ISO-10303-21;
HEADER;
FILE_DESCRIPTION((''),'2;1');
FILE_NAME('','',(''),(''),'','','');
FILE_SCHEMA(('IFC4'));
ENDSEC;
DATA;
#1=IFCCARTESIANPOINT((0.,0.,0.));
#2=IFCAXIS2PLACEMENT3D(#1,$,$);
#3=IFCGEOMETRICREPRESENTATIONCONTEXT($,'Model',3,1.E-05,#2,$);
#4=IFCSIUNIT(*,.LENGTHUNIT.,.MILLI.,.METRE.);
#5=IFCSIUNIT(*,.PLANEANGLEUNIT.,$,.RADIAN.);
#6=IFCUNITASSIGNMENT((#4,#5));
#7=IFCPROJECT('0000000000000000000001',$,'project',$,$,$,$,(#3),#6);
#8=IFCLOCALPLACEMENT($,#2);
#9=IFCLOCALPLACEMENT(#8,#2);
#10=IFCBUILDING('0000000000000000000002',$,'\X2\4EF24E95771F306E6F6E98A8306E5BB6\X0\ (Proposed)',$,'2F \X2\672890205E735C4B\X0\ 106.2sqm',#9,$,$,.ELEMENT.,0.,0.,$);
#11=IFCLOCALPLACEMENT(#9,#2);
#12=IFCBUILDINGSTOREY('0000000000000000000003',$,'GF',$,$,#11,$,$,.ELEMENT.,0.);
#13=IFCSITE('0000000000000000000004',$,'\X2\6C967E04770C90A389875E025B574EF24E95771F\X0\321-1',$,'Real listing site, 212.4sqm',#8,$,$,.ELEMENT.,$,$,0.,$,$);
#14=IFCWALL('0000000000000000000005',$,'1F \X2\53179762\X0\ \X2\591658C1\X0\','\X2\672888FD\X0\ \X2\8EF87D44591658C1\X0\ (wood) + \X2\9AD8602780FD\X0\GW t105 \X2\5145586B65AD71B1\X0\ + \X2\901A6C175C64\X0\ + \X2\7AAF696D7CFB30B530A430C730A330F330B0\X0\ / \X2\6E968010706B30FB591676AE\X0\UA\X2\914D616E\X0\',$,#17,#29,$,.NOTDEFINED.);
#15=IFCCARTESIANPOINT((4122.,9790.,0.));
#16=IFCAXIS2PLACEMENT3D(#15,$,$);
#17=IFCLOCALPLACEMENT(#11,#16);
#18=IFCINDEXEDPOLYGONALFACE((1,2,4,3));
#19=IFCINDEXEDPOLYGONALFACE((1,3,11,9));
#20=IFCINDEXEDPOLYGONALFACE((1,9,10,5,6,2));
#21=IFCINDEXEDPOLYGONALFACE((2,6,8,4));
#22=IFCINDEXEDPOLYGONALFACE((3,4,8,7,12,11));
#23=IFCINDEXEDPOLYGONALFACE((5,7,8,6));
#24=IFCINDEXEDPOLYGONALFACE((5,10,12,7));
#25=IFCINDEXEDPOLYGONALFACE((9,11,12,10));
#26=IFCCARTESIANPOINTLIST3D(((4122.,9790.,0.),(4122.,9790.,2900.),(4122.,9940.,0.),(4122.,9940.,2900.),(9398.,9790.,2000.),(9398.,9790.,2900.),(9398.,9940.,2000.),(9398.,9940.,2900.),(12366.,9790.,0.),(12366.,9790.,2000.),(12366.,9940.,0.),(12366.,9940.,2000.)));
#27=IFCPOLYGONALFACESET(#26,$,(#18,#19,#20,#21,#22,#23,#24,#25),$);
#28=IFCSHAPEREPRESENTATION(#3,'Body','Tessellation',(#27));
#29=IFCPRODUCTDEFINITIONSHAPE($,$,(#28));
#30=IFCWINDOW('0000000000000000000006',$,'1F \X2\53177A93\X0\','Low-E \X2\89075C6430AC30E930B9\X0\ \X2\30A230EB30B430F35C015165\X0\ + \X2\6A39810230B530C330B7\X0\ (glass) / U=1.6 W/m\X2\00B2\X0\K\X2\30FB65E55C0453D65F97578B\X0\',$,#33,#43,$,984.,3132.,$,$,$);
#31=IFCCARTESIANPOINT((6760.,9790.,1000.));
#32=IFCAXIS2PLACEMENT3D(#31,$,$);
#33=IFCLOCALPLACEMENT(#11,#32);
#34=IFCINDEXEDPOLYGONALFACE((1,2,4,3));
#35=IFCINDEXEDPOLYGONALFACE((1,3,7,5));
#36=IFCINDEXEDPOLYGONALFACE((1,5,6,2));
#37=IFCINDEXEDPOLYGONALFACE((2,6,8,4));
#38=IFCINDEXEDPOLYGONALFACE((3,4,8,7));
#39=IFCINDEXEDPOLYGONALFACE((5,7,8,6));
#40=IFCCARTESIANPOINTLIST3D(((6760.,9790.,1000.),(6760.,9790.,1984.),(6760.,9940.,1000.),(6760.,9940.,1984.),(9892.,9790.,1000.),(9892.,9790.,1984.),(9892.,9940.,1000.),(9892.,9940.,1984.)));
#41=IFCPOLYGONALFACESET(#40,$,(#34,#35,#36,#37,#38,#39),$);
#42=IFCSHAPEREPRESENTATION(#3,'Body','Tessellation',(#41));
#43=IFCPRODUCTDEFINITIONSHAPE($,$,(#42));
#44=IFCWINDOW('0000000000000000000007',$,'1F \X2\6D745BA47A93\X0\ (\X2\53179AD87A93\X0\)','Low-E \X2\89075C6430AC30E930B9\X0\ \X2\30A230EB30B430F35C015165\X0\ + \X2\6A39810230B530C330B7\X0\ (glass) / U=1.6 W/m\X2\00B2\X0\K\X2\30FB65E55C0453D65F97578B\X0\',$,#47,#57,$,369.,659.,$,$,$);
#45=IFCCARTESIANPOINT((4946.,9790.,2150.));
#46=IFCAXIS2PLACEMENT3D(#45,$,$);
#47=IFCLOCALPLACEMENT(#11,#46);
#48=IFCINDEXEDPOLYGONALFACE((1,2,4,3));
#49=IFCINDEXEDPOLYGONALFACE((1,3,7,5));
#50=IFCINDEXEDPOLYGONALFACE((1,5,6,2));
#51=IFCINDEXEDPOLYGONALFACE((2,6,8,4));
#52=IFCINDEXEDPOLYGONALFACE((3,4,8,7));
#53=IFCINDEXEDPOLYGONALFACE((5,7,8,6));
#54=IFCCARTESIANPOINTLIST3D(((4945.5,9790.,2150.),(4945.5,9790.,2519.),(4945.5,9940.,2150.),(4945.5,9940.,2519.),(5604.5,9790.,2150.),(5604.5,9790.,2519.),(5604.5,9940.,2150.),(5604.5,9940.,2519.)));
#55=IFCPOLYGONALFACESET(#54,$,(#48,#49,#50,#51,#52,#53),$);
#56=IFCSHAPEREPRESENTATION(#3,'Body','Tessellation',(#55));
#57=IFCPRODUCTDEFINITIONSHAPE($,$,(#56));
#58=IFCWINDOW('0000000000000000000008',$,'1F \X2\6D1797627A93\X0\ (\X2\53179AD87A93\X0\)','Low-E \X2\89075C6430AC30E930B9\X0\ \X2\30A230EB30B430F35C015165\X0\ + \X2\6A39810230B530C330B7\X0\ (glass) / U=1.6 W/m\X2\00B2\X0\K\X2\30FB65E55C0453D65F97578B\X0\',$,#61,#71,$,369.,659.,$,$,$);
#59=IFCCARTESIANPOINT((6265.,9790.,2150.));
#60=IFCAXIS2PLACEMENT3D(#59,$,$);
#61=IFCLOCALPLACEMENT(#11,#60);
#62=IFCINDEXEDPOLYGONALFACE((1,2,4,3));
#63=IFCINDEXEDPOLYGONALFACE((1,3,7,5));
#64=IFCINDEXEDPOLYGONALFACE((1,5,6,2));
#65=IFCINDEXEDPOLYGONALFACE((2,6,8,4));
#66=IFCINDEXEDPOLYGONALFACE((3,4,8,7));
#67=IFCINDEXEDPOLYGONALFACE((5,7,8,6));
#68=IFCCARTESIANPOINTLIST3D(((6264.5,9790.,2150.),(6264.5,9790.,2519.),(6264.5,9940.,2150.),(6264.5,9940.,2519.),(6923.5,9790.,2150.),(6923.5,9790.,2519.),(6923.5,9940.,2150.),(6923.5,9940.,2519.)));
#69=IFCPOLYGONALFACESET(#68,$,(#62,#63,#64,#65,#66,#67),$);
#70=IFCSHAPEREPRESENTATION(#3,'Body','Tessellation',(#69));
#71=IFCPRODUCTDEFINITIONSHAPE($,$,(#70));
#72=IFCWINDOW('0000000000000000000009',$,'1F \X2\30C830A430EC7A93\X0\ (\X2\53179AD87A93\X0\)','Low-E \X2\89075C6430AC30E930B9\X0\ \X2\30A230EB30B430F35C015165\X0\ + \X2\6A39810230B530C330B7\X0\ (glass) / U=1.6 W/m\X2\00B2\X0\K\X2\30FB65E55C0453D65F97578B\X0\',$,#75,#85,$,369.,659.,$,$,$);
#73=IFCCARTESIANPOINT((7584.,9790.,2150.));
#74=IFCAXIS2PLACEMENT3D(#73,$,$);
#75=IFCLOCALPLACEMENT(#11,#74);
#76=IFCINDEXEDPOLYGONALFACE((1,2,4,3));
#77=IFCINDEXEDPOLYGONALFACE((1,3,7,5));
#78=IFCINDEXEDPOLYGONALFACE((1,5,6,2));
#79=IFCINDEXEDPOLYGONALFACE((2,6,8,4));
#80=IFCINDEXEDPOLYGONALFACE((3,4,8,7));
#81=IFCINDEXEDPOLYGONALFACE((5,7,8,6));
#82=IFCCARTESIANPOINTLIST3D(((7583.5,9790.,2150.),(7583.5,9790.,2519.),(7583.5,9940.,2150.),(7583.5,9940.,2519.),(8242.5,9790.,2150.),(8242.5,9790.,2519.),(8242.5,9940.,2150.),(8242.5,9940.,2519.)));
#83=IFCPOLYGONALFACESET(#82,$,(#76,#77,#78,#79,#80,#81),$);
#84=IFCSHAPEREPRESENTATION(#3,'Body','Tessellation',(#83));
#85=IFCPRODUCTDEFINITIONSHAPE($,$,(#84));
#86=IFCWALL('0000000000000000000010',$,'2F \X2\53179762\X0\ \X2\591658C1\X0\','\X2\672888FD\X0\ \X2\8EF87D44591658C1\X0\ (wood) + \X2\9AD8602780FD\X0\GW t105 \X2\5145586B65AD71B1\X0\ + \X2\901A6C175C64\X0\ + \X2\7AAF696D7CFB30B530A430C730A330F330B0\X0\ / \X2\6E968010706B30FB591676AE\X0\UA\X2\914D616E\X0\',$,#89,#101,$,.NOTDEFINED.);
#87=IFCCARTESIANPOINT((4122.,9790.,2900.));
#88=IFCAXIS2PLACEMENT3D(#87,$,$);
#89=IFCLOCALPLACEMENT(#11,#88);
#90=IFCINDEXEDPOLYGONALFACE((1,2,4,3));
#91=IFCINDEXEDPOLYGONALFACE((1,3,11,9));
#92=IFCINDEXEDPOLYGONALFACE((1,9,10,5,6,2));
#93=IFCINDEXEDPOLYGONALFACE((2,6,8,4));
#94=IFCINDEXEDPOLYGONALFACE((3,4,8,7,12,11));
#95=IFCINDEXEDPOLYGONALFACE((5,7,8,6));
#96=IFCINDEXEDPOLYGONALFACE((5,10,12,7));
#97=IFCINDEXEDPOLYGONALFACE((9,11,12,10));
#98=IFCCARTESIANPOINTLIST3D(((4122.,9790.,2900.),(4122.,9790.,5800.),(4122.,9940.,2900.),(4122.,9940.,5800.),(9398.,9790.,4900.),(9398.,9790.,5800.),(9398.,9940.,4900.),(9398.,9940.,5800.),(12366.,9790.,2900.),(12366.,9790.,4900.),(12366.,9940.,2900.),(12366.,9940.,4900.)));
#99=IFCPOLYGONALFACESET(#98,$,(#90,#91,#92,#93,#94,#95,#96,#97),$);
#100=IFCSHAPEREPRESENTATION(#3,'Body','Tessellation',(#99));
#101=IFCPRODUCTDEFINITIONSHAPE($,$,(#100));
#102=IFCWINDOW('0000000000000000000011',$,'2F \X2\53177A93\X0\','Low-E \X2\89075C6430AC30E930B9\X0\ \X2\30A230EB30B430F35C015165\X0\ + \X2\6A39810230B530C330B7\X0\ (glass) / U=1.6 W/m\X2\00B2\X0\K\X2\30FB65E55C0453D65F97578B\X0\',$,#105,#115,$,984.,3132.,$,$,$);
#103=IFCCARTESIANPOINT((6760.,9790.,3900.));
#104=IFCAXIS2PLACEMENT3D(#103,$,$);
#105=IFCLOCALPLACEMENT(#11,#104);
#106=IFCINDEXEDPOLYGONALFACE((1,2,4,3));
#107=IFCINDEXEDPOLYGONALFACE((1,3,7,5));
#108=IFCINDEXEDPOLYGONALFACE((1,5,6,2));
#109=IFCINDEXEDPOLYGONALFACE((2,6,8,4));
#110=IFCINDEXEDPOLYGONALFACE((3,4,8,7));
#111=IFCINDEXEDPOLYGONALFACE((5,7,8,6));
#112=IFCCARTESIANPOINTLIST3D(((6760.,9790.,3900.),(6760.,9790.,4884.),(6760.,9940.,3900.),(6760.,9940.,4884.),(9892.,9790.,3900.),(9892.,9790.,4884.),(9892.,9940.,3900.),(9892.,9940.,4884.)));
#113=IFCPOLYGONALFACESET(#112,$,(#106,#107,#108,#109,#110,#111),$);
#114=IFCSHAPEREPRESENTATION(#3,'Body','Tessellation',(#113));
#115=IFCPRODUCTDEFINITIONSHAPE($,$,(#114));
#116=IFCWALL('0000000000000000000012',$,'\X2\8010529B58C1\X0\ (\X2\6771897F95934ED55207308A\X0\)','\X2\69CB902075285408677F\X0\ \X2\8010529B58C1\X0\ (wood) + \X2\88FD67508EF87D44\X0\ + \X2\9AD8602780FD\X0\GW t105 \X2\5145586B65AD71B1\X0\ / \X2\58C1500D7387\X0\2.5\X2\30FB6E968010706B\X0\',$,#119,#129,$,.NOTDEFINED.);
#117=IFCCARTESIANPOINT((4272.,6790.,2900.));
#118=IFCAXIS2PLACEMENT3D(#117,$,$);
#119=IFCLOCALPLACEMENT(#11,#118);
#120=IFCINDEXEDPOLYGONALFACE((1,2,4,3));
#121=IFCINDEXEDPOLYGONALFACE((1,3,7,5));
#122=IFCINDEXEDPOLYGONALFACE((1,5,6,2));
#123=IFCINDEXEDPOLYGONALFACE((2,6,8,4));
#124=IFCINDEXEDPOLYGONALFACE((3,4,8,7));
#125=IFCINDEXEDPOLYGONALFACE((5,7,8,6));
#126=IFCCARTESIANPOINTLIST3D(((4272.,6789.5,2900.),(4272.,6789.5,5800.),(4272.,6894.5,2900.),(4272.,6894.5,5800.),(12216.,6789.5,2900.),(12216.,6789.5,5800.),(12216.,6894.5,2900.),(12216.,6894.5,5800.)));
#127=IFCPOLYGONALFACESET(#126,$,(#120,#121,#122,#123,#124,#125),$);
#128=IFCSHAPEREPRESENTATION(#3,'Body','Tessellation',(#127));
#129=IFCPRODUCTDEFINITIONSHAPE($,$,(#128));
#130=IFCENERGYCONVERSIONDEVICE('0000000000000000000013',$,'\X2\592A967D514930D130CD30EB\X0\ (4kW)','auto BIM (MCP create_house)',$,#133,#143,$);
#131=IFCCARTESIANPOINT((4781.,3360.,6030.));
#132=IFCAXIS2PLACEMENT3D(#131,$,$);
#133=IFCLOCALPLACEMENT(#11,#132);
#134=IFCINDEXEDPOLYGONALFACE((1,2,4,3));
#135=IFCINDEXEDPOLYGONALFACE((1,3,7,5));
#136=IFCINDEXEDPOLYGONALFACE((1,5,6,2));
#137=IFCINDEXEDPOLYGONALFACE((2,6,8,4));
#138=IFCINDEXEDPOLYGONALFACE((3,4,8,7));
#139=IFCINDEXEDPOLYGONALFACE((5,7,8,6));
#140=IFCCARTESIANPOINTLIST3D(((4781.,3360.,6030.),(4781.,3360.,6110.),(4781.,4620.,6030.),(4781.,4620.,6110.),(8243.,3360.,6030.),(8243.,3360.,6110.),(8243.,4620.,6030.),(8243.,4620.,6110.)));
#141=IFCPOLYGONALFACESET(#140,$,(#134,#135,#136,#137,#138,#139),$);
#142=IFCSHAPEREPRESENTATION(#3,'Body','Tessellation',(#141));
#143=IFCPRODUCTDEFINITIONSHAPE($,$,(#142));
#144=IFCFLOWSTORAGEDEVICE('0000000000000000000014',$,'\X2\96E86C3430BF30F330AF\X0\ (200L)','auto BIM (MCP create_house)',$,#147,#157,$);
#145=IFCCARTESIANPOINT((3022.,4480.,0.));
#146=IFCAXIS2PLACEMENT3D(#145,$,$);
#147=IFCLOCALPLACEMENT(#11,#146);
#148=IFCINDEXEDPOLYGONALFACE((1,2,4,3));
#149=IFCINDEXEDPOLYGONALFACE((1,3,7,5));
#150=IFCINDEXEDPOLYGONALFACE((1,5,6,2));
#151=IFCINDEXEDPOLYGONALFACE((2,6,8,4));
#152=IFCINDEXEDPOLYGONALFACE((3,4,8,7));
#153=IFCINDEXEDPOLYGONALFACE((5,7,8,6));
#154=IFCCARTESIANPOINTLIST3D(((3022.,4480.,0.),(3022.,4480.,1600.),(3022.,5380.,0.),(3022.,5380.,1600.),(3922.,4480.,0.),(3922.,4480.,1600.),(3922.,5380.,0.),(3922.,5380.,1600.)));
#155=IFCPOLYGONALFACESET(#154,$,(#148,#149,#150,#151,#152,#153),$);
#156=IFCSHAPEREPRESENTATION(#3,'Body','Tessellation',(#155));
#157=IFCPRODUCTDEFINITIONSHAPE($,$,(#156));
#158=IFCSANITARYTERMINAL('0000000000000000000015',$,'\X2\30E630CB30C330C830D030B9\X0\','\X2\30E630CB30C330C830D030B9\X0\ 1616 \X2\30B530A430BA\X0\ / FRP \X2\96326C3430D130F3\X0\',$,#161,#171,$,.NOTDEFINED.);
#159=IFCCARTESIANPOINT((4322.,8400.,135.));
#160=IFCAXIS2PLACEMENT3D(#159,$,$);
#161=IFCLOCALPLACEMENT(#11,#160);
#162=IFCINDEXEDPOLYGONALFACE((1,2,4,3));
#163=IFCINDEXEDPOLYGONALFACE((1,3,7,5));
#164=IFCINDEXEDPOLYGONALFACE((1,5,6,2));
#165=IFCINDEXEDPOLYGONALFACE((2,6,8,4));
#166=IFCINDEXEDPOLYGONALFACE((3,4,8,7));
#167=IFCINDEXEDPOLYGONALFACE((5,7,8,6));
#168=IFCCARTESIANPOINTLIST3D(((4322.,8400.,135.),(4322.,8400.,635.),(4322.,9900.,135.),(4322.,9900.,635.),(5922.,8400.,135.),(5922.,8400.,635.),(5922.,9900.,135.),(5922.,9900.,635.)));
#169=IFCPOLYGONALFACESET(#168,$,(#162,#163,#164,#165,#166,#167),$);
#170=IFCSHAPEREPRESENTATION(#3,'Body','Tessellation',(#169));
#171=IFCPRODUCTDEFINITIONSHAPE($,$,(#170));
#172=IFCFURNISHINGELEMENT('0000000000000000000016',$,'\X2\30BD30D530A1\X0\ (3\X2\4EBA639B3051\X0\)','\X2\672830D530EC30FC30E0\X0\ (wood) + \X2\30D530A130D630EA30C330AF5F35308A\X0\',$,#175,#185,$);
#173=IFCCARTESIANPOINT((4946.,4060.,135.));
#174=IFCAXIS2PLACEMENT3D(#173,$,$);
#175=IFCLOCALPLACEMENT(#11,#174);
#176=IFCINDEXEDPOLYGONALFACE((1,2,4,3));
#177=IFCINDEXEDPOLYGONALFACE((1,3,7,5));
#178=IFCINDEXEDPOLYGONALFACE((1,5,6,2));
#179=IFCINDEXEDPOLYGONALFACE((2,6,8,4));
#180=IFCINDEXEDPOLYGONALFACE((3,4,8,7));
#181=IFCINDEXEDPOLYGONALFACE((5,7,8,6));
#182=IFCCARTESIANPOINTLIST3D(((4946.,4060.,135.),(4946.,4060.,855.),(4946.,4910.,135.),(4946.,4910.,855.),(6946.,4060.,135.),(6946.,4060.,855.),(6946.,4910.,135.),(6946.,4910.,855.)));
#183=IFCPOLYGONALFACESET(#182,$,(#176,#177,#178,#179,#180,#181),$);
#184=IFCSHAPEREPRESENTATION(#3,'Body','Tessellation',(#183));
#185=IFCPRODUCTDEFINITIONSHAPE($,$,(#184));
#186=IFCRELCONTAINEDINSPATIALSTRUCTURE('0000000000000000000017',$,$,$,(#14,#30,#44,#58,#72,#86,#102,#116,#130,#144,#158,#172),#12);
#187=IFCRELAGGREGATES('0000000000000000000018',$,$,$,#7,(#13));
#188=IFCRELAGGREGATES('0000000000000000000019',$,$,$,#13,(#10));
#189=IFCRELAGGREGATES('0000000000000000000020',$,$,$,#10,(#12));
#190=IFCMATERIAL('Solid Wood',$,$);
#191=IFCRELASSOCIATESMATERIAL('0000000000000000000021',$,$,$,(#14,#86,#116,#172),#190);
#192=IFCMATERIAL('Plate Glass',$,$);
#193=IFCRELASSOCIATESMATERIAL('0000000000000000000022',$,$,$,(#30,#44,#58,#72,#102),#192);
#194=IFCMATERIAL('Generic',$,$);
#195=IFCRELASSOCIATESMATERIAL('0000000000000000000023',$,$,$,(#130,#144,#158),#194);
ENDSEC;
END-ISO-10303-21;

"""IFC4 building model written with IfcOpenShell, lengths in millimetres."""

from ifc_helpers import new_model, si_unit, frame, frame_2d, origin, place, context, project, spatial, rectangle, extrude, material, element, fill, save


model = new_model("IFC4")

# Units and contexts
model_context = context("Model", 3, precision=1e-05, world=origin())
ifc_project = project(units=[si_unit("LENGTHUNIT", "METRE", prefix="MILLI"), si_unit("PLANEANGLEUNIT", "RADIAN")], contexts=[model_context])

# Site, building, storey
site_placement = place(None, origin())
site = spatial("IfcSite", under=ifc_project, at=site_placement, Name="沖縄県那覇市字仲井真321-1", ObjectType="Real listing site, 212.4sqm", CompositionType="ELEMENT", RefElevation=0.0)
building_placement = place(site_placement, origin())
building = spatial("IfcBuilding", under=site, at=building_placement, Name="仲井真の潮風の家 (Proposed)", ObjectType="2F 木造平屋 106.2sqm", CompositionType="ELEMENT", ElevationOfRefHeight=0.0, ElevationOfTerrain=0.0)
storey_placement = place(building_placement, origin())
storey = spatial("IfcBuildingStorey", under=building, at=storey_placement, Name="GF", CompositionType="ELEMENT", Elevation=0.0)

# Wall, openings, windows
ifc_material_1 = material(Name="Solid Wood")
wall_1_placement = place(storey_placement, frame((4122.0, 9790.0, 0.0)))
wall_1 = element("IfcWall", 1, at=wall_1_placement, inside=storey, material=ifc_material_1, Name="1F 北面 外壁", Description="木製 軸組外壁 (wood) + 高性能GW t105 充填断熱 + 通気層 + 窯業系サイディング / 準耐火・外皮UA配慮", PredefinedType="NOTDEFINED", context=model_context, shape_type="SweptSolid", body=[
    extrude(rectangle(XDim=8244.0, YDim=150.0, at=frame_2d((4122.0, 75.0))), frame((4122.0, 9790.0, 0.0)), (0.0, 0.0, 1.0), 2900.0),
])
opening_1_placement = place(storey_placement, frame((6760.0, 9790.0, 1000.0)))
opening_1 = element("IfcOpeningElement", 2, at=opening_1_placement, cuts=wall_1, PredefinedType="NOTDEFINED", context=model_context, shape_type="SweptSolid", body=[
    extrude(rectangle(XDim=3132.0, YDim=150.0, at=frame_2d((1566.0, 75.0))), frame((6760.0, 9790.0, 1000.0)), (0.0, 0.0, 1.0), 984.0),
])
opening_2_placement = place(storey_placement, frame((4946.0, 9790.0, 2150.0)))
opening_2 = element("IfcOpeningElement", 3, at=opening_2_placement, cuts=wall_1, PredefinedType="NOTDEFINED", context=model_context, shape_type="SweptSolid", body=[
    extrude(rectangle(XDim=659.0, YDim=150.0, at=frame_2d((329.0, 75.0))), frame((4946.0, 9790.0, 2150.0)), (0.0, 0.0, 1.0), 369.0),
])
opening_3_placement = place(storey_placement, frame((6265.0, 9790.0, 2150.0)))
opening_3 = element("IfcOpeningElement", 4, at=opening_3_placement, cuts=wall_1, PredefinedType="NOTDEFINED", context=model_context, shape_type="SweptSolid", body=[
    extrude(rectangle(XDim=659.0, YDim=150.0, at=frame_2d((329.0, 75.0))), frame((6265.0, 9790.0, 2150.0)), (0.0, 0.0, 1.0), 369.0),
])
opening_4_placement = place(storey_placement, frame((7584.0, 9790.0, 2150.0)))
opening_4 = element("IfcOpeningElement", 5, at=opening_4_placement, cuts=wall_1, PredefinedType="NOTDEFINED", context=model_context, shape_type="SweptSolid", body=[
    extrude(rectangle(XDim=659.0, YDim=150.0, at=frame_2d((329.0, 75.0))), frame((7584.0, 9790.0, 2150.0)), (0.0, 0.0, 1.0), 369.0),
])
ifc_material_2 = material(Name="Plate Glass")
window_1_placement = place(storey_placement, frame((6760.0, 9790.0, 1000.0)))
window_1 = element("IfcWindow", 6, at=window_1_placement, inside=storey, material=ifc_material_2, Name="1F 北窓", Description="Low-E 複層ガラス アルゴン封入 + 樹脂サッシ (glass) / U=1.6 W/m²K・日射取得型", OverallHeight=984.0, OverallWidth=3132.0, context=model_context, shape_type="SweptSolid", body=[
    extrude(rectangle(XDim=3132.0, YDim=150.0, at=frame_2d((1566.0, 75.0))), frame((6760.0, 9790.0, 1000.0)), (0.0, 0.0, 1.0), 984.0),
])
fill(opening_1, window_1)
window_2_placement = place(storey_placement, frame((4946.0, 9790.0, 2150.0)))
window_2 = element("IfcWindow", 7, at=window_2_placement, inside=storey, material=ifc_material_2, Name="1F 浴室窓 (北高窓)", Description="Low-E 複層ガラス アルゴン封入 + 樹脂サッシ (glass) / U=1.6 W/m²K・日射取得型", OverallHeight=369.0, OverallWidth=659.0, context=model_context, shape_type="SweptSolid", body=[
    extrude(rectangle(XDim=659.0, YDim=150.0, at=frame_2d((329.0, 75.0))), frame((4946.0, 9790.0, 2150.0)), (0.0, 0.0, 1.0), 369.0),
])
fill(opening_2, window_2)
window_3_placement = place(storey_placement, frame((6265.0, 9790.0, 2150.0)))
window_3 = element("IfcWindow", 8, at=window_3_placement, inside=storey, material=ifc_material_2, Name="1F 洗面窓 (北高窓)", Description="Low-E 複層ガラス アルゴン封入 + 樹脂サッシ (glass) / U=1.6 W/m²K・日射取得型", OverallHeight=369.0, OverallWidth=659.0, context=model_context, shape_type="SweptSolid", body=[
    extrude(rectangle(XDim=659.0, YDim=150.0, at=frame_2d((329.0, 75.0))), frame((6265.0, 9790.0, 2150.0)), (0.0, 0.0, 1.0), 369.0),
])
fill(opening_3, window_3)
window_4_placement = place(storey_placement, frame((7584.0, 9790.0, 2150.0)))
window_4 = element("IfcWindow", 9, at=window_4_placement, inside=storey, material=ifc_material_2, Name="1F トイレ窓 (北高窓)", Description="Low-E 複層ガラス アルゴン封入 + 樹脂サッシ (glass) / U=1.6 W/m²K・日射取得型", OverallHeight=369.0, OverallWidth=659.0, context=model_context, shape_type="SweptSolid", body=[
    extrude(rectangle(XDim=659.0, YDim=150.0, at=frame_2d((329.0, 75.0))), frame((7584.0, 9790.0, 2150.0)), (0.0, 0.0, 1.0), 369.0),
])
fill(opening_4, window_4)

# Wall, opening, window
wall_2_placement = place(storey_placement, frame((4122.0, 9790.0, 2900.0)))
wall_2 = element("IfcWall", 10, at=wall_2_placement, inside=storey, material=ifc_material_1, Name="2F 北面 外壁", Description="木製 軸組外壁 (wood) + 高性能GW t105 充填断熱 + 通気層 + 窯業系サイディング / 準耐火・外皮UA配慮", PredefinedType="NOTDEFINED", context=model_context, shape_type="SweptSolid", body=[
    extrude(rectangle(XDim=8244.0, YDim=150.0, at=frame_2d((4122.0, 75.0))), frame((4122.0, 9790.0, 2900.0)), (0.0, 0.0, 1.0), 2900.0),
])
opening_5_placement = place(storey_placement, frame((6760.0, 9790.0, 3900.0)))
opening_5 = element("IfcOpeningElement", 11, at=opening_5_placement, cuts=wall_2, PredefinedType="NOTDEFINED", context=model_context, shape_type="SweptSolid", body=[
    extrude(rectangle(XDim=3132.0, YDim=150.0, at=frame_2d((1566.0, 75.0))), frame((6760.0, 9790.0, 3900.0)), (0.0, 0.0, 1.0), 984.0),
])
window_5_placement = place(storey_placement, frame((6760.0, 9790.0, 3900.0)))
window_5 = element("IfcWindow", 12, at=window_5_placement, inside=storey, material=ifc_material_2, Name="2F 北窓", Description="Low-E 複層ガラス アルゴン封入 + 樹脂サッシ (glass) / U=1.6 W/m²K・日射取得型", OverallHeight=984.0, OverallWidth=3132.0, context=model_context, shape_type="SweptSolid", body=[
    extrude(rectangle(XDim=3132.0, YDim=150.0, at=frame_2d((1566.0, 75.0))), frame((6760.0, 9790.0, 3900.0)), (0.0, 0.0, 1.0), 984.0),
])
fill(opening_5, window_5)

# Wall
wall_3_placement = place(storey_placement, frame((4272.0, 6790.0, 2900.0)))
element("IfcWall", 13, at=wall_3_placement, inside=storey, material=ifc_material_1, Name="耐力壁 (東西間仕切り)", Description="構造用合板 耐力壁 (wood) + 製材軸組 + 高性能GW t105 充填断熱 / 壁倍率2.5・準耐火", PredefinedType="NOTDEFINED", context=model_context, shape_type="SweptSolid", body=[
    extrude(rectangle(XDim=7944.0, YDim=105.0, at=frame_2d((3972.0, 52.0))), frame((4272.0, 6790.0, 2900.0)), (0.0, 0.0, 1.0), 2900.0),
])

# Energy conversion device
ifc_material_3 = material(Name="Generic")
energy_conversion_device_placement = place(storey_placement, frame((4781.0, 3360.0, 6030.0)))
element("IfcEnergyConversionDevice", 14, at=energy_conversion_device_placement, inside=storey, material=ifc_material_3, Name="太陽光パネル (4kW)", Description="auto BIM (MCP create_house)", context=model_context, shape_type="SweptSolid", body=[
    extrude(rectangle(XDim=3462.0, YDim=1260.0, at=frame_2d((1731.0, 630.0))), frame((4781.0, 3360.0, 6030.0)), (0.0, 0.0, 1.0), 80.0),
])

# Flow storage device
flow_storage_device_placement = place(storey_placement, frame((3022.0, 4480.0, 0.0)))
element("IfcFlowStorageDevice", 15, at=flow_storage_device_placement, inside=storey, material=ifc_material_3, Name="雨水タンク (200L)", Description="auto BIM (MCP create_house)", context=model_context, shape_type="SweptSolid", body=[
    extrude(rectangle(XDim=900.0, YDim=900.0, at=frame_2d((450.0, 450.0))), frame((3022.0, 4480.0, 0.0)), (0.0, 0.0, 1.0), 1600.0),
])

# Sanitary terminal
sanitary_terminal_placement = place(storey_placement, frame((4322.0, 8400.0, 135.0)))
element("IfcSanitaryTerminal", 16, at=sanitary_terminal_placement, inside=storey, material=ifc_material_3, Name="ユニットバス", Description="ユニットバス 1616 サイズ / FRP 防水パン", PredefinedType="NOTDEFINED", context=model_context, shape_type="SweptSolid", body=[
    extrude(rectangle(XDim=1600.0, YDim=1500.0, at=frame_2d((800.0, 750.0))), frame((4322.0, 8400.0, 135.0)), (0.0, 0.0, 1.0), 500.0),
])

# Furnishing element
furnishing_1_placement = place(storey_placement, frame((4946.0, 4060.0, 135.0)))
element("IfcFurnishingElement", 17, at=furnishing_1_placement, inside=storey, material=ifc_material_1, Name="ソファ (3人掛け)", Description="木フレーム (wood) + ファブリック張り", context=model_context, shape_type="SweptSolid", body=[
    extrude(rectangle(XDim=2000.0, YDim=850.0, at=frame_2d((1000.0, 425.0))), frame((4946.0, 4060.0, 135.0)), (0.0, 0.0, 1.0), 720.0),
])

save(model, "model.ifc")
